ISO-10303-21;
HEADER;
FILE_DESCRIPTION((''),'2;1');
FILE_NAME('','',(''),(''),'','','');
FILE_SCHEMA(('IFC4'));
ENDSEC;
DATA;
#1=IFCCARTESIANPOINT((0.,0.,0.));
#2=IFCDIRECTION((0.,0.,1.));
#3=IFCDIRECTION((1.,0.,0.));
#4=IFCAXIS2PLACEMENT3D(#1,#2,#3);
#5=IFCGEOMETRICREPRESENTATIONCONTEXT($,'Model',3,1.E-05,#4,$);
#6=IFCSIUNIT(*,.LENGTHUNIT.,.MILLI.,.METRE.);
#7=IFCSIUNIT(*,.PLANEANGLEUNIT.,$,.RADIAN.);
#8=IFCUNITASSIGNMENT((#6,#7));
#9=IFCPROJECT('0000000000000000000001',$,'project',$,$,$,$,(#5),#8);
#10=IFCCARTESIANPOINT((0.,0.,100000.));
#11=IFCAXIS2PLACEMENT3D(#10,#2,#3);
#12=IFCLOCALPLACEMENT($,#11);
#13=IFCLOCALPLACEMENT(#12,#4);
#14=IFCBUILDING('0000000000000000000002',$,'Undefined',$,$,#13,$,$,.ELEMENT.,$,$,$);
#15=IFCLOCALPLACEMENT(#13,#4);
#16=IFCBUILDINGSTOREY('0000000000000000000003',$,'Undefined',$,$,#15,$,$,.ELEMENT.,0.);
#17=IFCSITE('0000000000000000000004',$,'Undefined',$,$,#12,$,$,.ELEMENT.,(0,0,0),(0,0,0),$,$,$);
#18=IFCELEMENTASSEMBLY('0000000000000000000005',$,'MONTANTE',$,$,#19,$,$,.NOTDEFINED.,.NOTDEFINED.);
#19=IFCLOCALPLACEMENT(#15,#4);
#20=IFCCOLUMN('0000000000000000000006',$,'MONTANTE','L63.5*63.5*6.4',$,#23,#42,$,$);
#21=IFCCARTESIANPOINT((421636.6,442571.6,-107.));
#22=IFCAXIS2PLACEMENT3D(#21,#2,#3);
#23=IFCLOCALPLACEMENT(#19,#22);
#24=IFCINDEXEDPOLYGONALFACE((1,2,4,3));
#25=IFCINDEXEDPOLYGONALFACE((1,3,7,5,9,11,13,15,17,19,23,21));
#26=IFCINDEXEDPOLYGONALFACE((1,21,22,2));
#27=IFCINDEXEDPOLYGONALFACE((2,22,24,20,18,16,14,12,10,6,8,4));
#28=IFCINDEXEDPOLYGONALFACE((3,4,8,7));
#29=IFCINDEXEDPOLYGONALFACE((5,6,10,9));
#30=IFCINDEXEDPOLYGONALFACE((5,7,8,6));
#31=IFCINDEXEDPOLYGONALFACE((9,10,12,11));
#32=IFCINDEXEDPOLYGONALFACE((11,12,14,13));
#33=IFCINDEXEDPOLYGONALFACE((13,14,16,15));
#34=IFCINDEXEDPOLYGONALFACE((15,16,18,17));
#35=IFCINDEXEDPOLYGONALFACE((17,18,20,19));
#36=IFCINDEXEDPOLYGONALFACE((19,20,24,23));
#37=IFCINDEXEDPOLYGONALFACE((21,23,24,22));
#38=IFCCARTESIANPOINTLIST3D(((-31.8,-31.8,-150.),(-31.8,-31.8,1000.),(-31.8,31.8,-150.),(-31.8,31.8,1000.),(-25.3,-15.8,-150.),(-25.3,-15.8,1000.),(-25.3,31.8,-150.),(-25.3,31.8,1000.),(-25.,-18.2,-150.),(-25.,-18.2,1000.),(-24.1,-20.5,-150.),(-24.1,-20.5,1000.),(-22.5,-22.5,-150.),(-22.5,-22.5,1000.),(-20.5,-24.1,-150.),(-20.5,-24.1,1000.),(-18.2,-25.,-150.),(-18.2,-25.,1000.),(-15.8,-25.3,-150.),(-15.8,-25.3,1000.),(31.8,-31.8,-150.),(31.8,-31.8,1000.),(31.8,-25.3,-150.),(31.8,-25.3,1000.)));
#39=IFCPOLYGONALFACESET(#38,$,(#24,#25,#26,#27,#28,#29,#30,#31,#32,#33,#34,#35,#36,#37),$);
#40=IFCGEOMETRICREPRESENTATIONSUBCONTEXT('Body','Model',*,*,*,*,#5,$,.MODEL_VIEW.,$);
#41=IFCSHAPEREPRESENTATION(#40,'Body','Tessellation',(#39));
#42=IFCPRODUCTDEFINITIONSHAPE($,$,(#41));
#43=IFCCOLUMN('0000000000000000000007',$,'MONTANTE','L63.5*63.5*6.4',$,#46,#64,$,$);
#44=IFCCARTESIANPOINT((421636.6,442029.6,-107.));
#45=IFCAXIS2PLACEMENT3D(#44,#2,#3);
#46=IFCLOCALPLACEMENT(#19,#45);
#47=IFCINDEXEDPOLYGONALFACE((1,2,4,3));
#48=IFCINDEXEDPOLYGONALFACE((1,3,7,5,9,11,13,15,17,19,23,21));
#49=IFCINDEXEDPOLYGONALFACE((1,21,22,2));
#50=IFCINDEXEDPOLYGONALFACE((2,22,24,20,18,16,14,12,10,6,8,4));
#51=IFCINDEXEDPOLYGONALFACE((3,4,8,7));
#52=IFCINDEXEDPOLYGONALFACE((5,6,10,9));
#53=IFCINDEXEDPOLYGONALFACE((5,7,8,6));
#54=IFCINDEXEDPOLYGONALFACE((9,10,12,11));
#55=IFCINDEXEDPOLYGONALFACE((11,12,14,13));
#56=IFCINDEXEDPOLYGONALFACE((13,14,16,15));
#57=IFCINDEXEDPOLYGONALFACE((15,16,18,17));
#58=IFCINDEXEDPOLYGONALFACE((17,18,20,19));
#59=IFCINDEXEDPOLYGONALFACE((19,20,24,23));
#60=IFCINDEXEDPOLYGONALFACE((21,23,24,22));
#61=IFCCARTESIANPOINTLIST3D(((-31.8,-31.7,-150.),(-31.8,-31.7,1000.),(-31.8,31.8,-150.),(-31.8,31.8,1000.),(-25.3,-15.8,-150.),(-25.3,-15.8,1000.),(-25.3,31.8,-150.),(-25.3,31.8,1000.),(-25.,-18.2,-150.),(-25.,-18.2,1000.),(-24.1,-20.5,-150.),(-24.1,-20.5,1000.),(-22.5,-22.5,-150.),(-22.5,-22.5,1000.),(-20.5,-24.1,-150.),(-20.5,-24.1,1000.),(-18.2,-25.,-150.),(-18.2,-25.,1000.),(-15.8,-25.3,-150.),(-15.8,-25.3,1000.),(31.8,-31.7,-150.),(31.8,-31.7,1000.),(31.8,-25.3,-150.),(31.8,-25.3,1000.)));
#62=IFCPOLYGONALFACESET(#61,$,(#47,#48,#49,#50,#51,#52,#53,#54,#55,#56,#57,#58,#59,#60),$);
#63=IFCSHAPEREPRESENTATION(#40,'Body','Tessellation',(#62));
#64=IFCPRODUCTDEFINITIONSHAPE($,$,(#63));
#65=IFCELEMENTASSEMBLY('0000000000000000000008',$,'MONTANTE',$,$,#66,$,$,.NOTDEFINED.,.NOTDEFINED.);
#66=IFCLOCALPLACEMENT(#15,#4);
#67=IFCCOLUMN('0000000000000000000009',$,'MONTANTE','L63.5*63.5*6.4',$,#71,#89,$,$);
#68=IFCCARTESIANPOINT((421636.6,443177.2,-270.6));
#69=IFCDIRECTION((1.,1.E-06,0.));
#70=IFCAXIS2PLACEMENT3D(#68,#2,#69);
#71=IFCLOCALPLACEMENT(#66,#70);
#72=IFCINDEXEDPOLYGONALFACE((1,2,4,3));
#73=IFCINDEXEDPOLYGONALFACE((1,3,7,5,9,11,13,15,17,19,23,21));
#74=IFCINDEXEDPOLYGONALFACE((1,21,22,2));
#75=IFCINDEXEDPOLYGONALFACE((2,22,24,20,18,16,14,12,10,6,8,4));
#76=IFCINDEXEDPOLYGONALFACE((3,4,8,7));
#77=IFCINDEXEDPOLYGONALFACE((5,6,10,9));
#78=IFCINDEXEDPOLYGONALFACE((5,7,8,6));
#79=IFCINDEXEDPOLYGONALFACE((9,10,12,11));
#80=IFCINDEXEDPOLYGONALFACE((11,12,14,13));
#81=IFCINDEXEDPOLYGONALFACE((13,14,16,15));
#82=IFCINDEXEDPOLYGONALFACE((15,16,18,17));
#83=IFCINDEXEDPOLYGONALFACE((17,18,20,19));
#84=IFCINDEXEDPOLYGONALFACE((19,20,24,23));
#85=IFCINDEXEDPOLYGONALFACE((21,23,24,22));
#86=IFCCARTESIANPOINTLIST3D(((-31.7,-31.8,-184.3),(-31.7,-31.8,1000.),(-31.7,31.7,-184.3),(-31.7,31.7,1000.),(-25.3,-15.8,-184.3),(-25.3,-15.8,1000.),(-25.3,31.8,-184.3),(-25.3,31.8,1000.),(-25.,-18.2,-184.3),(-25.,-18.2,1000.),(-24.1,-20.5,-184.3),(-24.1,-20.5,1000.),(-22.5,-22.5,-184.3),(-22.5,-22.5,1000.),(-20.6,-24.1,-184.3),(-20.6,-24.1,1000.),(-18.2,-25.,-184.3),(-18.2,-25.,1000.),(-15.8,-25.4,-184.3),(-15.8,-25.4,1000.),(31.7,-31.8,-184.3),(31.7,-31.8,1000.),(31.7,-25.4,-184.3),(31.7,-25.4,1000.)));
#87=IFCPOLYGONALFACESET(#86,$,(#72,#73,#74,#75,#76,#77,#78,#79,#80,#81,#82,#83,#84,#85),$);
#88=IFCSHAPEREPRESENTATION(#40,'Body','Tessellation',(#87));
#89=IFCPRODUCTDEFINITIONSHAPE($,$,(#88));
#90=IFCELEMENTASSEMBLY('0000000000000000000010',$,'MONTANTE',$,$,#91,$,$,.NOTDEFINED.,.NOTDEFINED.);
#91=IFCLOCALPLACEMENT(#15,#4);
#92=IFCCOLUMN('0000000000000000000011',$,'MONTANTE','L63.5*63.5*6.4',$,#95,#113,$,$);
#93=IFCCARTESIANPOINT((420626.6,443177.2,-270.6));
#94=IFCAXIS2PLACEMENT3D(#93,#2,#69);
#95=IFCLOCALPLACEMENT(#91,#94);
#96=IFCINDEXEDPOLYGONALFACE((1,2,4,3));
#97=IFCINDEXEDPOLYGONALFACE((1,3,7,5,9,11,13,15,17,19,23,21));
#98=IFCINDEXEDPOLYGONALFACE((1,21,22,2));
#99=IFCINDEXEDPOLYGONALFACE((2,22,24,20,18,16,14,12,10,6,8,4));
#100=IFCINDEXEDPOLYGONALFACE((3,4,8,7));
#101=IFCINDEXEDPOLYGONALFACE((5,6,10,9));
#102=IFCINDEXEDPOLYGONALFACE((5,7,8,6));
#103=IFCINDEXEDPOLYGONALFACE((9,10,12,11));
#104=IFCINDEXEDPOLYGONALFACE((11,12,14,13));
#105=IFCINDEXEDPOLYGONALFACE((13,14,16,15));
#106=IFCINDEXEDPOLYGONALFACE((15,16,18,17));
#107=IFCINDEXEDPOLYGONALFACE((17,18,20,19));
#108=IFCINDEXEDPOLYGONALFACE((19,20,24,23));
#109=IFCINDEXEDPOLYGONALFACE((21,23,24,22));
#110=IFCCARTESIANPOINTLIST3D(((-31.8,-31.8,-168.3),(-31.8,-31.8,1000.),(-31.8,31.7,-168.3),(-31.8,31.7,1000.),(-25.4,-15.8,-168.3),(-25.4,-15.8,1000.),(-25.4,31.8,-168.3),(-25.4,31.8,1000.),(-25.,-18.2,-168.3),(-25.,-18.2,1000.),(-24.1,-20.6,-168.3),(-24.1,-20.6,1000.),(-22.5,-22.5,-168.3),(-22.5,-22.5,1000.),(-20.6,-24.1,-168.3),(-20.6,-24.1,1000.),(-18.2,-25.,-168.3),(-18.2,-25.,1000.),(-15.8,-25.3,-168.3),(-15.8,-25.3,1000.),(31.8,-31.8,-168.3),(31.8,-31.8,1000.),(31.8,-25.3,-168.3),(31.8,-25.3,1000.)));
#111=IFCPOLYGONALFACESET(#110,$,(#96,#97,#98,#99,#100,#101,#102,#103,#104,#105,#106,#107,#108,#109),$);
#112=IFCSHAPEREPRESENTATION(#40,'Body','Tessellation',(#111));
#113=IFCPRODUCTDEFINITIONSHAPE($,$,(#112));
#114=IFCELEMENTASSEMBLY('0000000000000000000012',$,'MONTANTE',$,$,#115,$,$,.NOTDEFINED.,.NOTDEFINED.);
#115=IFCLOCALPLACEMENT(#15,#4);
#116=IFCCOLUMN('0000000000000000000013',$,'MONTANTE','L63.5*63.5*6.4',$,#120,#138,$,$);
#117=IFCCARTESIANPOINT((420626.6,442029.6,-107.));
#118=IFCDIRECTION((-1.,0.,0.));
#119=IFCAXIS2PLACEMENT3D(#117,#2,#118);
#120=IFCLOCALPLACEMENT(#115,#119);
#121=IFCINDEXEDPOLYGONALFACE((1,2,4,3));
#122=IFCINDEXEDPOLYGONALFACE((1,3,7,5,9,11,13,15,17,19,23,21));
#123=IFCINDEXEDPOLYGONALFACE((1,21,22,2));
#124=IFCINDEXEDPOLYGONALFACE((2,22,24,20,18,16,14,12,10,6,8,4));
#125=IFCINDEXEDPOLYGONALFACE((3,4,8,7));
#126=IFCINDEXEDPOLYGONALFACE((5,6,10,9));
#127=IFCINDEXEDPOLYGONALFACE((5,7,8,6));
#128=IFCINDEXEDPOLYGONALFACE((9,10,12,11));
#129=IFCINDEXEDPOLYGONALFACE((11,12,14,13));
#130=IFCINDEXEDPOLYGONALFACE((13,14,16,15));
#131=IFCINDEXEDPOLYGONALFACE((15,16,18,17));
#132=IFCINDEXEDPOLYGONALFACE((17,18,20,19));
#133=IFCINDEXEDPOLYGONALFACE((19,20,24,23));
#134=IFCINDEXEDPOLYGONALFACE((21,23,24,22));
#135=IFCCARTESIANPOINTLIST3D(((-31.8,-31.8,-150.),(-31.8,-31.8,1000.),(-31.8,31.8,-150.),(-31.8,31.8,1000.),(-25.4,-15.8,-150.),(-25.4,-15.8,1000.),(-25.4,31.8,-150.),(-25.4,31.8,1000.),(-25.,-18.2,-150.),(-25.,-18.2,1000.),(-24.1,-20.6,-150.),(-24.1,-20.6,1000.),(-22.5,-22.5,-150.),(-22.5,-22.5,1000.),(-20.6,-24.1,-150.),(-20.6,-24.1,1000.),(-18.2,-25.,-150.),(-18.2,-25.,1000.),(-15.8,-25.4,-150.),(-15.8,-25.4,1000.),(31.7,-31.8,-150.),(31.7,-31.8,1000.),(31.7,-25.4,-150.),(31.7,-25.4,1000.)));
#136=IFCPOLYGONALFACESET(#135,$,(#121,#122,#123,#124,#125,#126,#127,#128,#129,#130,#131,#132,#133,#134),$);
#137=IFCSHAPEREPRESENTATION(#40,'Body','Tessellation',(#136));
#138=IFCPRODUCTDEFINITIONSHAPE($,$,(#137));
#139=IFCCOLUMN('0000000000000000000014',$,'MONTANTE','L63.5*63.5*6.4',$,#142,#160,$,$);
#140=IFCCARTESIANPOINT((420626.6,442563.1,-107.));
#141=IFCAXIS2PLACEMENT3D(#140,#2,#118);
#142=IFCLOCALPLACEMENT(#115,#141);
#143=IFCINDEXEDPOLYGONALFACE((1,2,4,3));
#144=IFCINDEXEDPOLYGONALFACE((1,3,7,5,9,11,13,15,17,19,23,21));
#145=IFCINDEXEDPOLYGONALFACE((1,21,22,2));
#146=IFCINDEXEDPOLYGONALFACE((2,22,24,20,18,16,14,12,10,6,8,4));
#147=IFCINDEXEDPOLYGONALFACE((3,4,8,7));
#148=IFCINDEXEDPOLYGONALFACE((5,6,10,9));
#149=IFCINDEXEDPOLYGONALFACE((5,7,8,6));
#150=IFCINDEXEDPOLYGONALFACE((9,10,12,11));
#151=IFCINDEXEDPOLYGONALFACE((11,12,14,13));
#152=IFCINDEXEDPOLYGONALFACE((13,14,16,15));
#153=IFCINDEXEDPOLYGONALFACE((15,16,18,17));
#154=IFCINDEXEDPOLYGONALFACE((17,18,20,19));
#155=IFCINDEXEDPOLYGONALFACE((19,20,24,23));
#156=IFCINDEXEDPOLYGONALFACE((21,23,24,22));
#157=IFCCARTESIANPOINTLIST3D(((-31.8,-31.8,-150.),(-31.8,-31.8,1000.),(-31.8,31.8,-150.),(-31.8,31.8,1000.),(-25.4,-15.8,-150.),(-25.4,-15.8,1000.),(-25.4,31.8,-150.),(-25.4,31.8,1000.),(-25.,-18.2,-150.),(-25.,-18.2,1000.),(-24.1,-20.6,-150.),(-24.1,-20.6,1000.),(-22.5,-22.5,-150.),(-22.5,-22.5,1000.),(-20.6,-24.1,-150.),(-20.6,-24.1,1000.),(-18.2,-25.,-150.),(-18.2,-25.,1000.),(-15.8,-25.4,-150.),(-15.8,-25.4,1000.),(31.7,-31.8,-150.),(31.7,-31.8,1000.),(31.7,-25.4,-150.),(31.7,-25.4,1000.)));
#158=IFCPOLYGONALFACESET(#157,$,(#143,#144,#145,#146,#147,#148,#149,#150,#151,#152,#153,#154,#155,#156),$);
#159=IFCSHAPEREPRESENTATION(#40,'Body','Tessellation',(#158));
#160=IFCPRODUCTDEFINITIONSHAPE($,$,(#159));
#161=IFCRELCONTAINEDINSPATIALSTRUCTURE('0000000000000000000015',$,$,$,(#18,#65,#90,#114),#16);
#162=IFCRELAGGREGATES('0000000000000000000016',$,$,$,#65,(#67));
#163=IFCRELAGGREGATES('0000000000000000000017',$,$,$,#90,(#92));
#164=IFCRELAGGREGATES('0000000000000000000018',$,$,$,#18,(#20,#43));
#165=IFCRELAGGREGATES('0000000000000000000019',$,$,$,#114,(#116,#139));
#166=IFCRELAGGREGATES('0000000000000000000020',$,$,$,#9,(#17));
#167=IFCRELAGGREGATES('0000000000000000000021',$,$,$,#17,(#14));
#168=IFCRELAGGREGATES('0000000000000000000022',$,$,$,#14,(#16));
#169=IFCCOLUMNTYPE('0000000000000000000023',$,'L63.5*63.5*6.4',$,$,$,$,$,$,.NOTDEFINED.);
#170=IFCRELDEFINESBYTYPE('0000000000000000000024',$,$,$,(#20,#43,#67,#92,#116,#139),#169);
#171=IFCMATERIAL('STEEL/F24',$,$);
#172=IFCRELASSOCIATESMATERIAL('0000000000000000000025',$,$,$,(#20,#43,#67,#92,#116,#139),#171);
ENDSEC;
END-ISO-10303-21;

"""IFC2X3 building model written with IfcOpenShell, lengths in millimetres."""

from ifc_helpers import new_model, si_unit, frame, origin_with_axes, origin_2d_with_axis, place, context, subcontext, project, spatial, l_section, extrude, clip, halfspace, material, type_object, element, aggregate, save


model = new_model("IFC2X3")

# Units and contexts
model_context = context("Model", 3, precision=1e-05, world=origin_with_axes())
body_context = subcontext(model_context, "Body", "Model", "MODEL_VIEW")
ifc_project = project(units=[si_unit("LENGTHUNIT", "METRE", prefix="MILLI"), si_unit("PLANEANGLEUNIT", "RADIAN")], contexts=[model_context])

# Site, building, storey
site_placement = place(None, frame((0.0, 0.0, 100000.0), z_axis=(0.0, 0.0, 1.0), x_axis=(1.0, 0.0, 0.0)))
site = spatial("IfcSite", under=ifc_project, at=site_placement, Name="Undefined", CompositionType="ELEMENT", RefLatitude=(0, 0, 0), RefLongitude=(0, 0, 0))
building_placement = place(site_placement, origin_with_axes())
building = spatial("IfcBuilding", under=site, at=building_placement, Name="Undefined", CompositionType="ELEMENT")
storey_placement = place(building_placement, origin_with_axes())
storey = spatial("IfcBuildingStorey", under=building, at=storey_placement, Name="Undefined", CompositionType="ELEMENT", Elevation=0.0)

# Element assembly, columns
assembly_1_placement = place(storey_placement, origin_with_axes())
assembly_1 = element("IfcElementAssembly", 1, at=assembly_1_placement, inside=storey, Name="MONTANTE", AssemblyPlace="NOTDEFINED", PredefinedType="NOTDEFINED")
ifc_material_1 = material(Name="STEEL/F24")
column_type = type_object("IfcColumnType", Name="L63.5*63.5*6.4", PredefinedType="NOTDEFINED")
column_1_placement = place(assembly_1_placement, frame((421636.6, 442571.6, -107.0), z_axis=(0.0, 0.0, 1.0), x_axis=(1.0, 0.0, 0.0)))
column_1 = element("IfcColumn", 2, at=column_1_placement, type_object=column_type, material=ifc_material_1, Name="MONTANTE", Description="L63.5*63.5*6.4", context=body_context, shape_type="Clipping", body=[
    clip(extrude(l_section(Depth=63.5, Width=63.5, Thickness=6.4, FilletRadius=9.6, at=origin_2d_with_axis()), frame((0.0, 0.0, 1000.0), z_axis=(0.0, 0.0, -1.0), x_axis=(0.0, 1.0, 0.0)), (0.0, 0.0, 1.0), 1150.0), halfspace(frame((0.0, 0.0, -150.0), z_axis=(0.0, 0.0, -1.0), x_axis=(0.0, 1.0, 0.0)), False)),
])
column_2_placement = place(assembly_1_placement, frame((421636.6, 442029.6, -107.0), z_axis=(0.0, 0.0, 1.0), x_axis=(1.0, 0.0, 0.0)))
column_2 = element("IfcColumn", 3, at=column_2_placement, type_object=column_type, material=ifc_material_1, Name="MONTANTE", Description="L63.5*63.5*6.4", context=body_context, shape_type="Clipping", body=[
    clip(extrude(l_section(Depth=63.5, Width=63.5, Thickness=6.4, FilletRadius=9.6, at=origin_2d_with_axis()), frame((0.0, 0.0, 1000.0), z_axis=(0.0, 0.0, -1.0), x_axis=(0.0, 1.0, 0.0)), (0.0, 0.0, 1.0), 1150.0), halfspace(frame((0.0, 0.0, -150.0), z_axis=(0.0, 0.0, -1.0), x_axis=(0.0, 1.0, 0.0)), False)),
])

# Element assemblies, columns
assembly_2_placement = place(storey_placement, origin_with_axes())
assembly_2 = element("IfcElementAssembly", 4, at=assembly_2_placement, inside=storey, Name="MONTANTE", AssemblyPlace="NOTDEFINED", PredefinedType="NOTDEFINED")
column_3_placement = place(assembly_2_placement, frame((421636.6, 443177.2, -270.6), z_axis=(0.0, 0.0, 1.0), x_axis=(1.0, 0.000001, 0.0)))
column_3 = element("IfcColumn", 5, at=column_3_placement, type_object=column_type, material=ifc_material_1, Name="MONTANTE", Description="L63.5*63.5*6.4", context=body_context, shape_type="Clipping", body=[
    clip(extrude(l_section(Depth=63.5, Width=63.5, Thickness=6.4, FilletRadius=9.6, at=origin_2d_with_axis()), frame((0.0, 0.0, 1000.0), z_axis=(0.0, 0.0, -1.0), x_axis=(0.0, 1.0, 0.0)), (0.0, 0.0, 1.0), 1184.3), halfspace(frame((0.0, 0.0, -184.3), z_axis=(0.0, 0.0, -1.0), x_axis=(0.0, 1.0, 0.0)), False)),
])
assembly_3_placement = place(storey_placement, origin_with_axes())
assembly_3 = element("IfcElementAssembly", 6, at=assembly_3_placement, inside=storey, Name="MONTANTE", AssemblyPlace="NOTDEFINED", PredefinedType="NOTDEFINED")
column_4_placement = place(assembly_3_placement, frame((420626.6, 443177.2, -270.6), z_axis=(0.0, 0.0, 1.0), x_axis=(1.0, 0.000001, 0.0)))
column_4 = element("IfcColumn", 7, at=column_4_placement, type_object=column_type, material=ifc_material_1, Name="MONTANTE", Description="L63.5*63.5*6.4", context=body_context, shape_type="Clipping", body=[
    clip(extrude(l_section(Depth=63.5, Width=63.5, Thickness=6.4, FilletRadius=9.6, at=origin_2d_with_axis()), frame((0.0, 0.0, 1000.0), z_axis=(0.0, 0.0, -1.0), x_axis=(0.0, 1.0, 0.0)), (0.0, 0.0, 1.0), 1168.3), halfspace(frame((0.0, 0.0, -168.3), z_axis=(0.0, 0.0, -1.0), x_axis=(0.0, -1.0, 0.0)), False)),
])

# Element assembly, columns
assembly_4_placement = place(storey_placement, origin_with_axes())
assembly_4 = element("IfcElementAssembly", 8, at=assembly_4_placement, inside=storey, Name="MONTANTE", AssemblyPlace="NOTDEFINED", PredefinedType="NOTDEFINED")
column_5_placement = place(assembly_4_placement, frame((420626.6, 442029.6, -107.0), z_axis=(0.0, 0.0, 1.0), x_axis=(-1.0, 0.0, 0.0)))
column_5 = element("IfcColumn", 9, at=column_5_placement, type_object=column_type, material=ifc_material_1, Name="MONTANTE", Description="L63.5*63.5*6.4", context=body_context, shape_type="Clipping", body=[
    clip(extrude(l_section(Depth=63.5, Width=63.5, Thickness=6.4, FilletRadius=9.6, at=origin_2d_with_axis()), frame((0.0, 0.0, 1000.0), z_axis=(0.0, 0.0, -1.0), x_axis=(0.0, 1.0, 0.0)), (0.0, 0.0, 1.0), 1150.0), halfspace(frame((0.0, 0.0, -150.0), z_axis=(0.0, 0.0, -1.0), x_axis=(0.0, 1.0, 0.0)), False)),
])
column_6_placement = place(assembly_4_placement, frame((420626.6, 442563.1, -107.0), z_axis=(0.0, 0.0, 1.0), x_axis=(-1.0, 0.0, 0.0)))
column_6 = element("IfcColumn", 10, at=column_6_placement, type_object=column_type, material=ifc_material_1, Name="MONTANTE", Description="L63.5*63.5*6.4", context=body_context, shape_type="Clipping", body=[
    clip(extrude(l_section(Depth=63.5, Width=63.5, Thickness=6.4, FilletRadius=9.6, at=origin_2d_with_axis()), frame((0.0, 0.0, 1000.0), z_axis=(0.0, 0.0, -1.0), x_axis=(0.0, 1.0, 0.0)), (0.0, 0.0, 1.0), 1150.0), halfspace(frame((0.0, 0.0, -150.0), z_axis=(0.0, 0.0, -1.0), x_axis=(0.0, 1.0, 0.0)), False)),
])

aggregate(assembly_2, [column_3])
aggregate(assembly_3, [column_4])

aggregate(assembly_1, [column_1, column_2])
aggregate(assembly_4, [column_5, column_6])

save(model, "model.ifc")
